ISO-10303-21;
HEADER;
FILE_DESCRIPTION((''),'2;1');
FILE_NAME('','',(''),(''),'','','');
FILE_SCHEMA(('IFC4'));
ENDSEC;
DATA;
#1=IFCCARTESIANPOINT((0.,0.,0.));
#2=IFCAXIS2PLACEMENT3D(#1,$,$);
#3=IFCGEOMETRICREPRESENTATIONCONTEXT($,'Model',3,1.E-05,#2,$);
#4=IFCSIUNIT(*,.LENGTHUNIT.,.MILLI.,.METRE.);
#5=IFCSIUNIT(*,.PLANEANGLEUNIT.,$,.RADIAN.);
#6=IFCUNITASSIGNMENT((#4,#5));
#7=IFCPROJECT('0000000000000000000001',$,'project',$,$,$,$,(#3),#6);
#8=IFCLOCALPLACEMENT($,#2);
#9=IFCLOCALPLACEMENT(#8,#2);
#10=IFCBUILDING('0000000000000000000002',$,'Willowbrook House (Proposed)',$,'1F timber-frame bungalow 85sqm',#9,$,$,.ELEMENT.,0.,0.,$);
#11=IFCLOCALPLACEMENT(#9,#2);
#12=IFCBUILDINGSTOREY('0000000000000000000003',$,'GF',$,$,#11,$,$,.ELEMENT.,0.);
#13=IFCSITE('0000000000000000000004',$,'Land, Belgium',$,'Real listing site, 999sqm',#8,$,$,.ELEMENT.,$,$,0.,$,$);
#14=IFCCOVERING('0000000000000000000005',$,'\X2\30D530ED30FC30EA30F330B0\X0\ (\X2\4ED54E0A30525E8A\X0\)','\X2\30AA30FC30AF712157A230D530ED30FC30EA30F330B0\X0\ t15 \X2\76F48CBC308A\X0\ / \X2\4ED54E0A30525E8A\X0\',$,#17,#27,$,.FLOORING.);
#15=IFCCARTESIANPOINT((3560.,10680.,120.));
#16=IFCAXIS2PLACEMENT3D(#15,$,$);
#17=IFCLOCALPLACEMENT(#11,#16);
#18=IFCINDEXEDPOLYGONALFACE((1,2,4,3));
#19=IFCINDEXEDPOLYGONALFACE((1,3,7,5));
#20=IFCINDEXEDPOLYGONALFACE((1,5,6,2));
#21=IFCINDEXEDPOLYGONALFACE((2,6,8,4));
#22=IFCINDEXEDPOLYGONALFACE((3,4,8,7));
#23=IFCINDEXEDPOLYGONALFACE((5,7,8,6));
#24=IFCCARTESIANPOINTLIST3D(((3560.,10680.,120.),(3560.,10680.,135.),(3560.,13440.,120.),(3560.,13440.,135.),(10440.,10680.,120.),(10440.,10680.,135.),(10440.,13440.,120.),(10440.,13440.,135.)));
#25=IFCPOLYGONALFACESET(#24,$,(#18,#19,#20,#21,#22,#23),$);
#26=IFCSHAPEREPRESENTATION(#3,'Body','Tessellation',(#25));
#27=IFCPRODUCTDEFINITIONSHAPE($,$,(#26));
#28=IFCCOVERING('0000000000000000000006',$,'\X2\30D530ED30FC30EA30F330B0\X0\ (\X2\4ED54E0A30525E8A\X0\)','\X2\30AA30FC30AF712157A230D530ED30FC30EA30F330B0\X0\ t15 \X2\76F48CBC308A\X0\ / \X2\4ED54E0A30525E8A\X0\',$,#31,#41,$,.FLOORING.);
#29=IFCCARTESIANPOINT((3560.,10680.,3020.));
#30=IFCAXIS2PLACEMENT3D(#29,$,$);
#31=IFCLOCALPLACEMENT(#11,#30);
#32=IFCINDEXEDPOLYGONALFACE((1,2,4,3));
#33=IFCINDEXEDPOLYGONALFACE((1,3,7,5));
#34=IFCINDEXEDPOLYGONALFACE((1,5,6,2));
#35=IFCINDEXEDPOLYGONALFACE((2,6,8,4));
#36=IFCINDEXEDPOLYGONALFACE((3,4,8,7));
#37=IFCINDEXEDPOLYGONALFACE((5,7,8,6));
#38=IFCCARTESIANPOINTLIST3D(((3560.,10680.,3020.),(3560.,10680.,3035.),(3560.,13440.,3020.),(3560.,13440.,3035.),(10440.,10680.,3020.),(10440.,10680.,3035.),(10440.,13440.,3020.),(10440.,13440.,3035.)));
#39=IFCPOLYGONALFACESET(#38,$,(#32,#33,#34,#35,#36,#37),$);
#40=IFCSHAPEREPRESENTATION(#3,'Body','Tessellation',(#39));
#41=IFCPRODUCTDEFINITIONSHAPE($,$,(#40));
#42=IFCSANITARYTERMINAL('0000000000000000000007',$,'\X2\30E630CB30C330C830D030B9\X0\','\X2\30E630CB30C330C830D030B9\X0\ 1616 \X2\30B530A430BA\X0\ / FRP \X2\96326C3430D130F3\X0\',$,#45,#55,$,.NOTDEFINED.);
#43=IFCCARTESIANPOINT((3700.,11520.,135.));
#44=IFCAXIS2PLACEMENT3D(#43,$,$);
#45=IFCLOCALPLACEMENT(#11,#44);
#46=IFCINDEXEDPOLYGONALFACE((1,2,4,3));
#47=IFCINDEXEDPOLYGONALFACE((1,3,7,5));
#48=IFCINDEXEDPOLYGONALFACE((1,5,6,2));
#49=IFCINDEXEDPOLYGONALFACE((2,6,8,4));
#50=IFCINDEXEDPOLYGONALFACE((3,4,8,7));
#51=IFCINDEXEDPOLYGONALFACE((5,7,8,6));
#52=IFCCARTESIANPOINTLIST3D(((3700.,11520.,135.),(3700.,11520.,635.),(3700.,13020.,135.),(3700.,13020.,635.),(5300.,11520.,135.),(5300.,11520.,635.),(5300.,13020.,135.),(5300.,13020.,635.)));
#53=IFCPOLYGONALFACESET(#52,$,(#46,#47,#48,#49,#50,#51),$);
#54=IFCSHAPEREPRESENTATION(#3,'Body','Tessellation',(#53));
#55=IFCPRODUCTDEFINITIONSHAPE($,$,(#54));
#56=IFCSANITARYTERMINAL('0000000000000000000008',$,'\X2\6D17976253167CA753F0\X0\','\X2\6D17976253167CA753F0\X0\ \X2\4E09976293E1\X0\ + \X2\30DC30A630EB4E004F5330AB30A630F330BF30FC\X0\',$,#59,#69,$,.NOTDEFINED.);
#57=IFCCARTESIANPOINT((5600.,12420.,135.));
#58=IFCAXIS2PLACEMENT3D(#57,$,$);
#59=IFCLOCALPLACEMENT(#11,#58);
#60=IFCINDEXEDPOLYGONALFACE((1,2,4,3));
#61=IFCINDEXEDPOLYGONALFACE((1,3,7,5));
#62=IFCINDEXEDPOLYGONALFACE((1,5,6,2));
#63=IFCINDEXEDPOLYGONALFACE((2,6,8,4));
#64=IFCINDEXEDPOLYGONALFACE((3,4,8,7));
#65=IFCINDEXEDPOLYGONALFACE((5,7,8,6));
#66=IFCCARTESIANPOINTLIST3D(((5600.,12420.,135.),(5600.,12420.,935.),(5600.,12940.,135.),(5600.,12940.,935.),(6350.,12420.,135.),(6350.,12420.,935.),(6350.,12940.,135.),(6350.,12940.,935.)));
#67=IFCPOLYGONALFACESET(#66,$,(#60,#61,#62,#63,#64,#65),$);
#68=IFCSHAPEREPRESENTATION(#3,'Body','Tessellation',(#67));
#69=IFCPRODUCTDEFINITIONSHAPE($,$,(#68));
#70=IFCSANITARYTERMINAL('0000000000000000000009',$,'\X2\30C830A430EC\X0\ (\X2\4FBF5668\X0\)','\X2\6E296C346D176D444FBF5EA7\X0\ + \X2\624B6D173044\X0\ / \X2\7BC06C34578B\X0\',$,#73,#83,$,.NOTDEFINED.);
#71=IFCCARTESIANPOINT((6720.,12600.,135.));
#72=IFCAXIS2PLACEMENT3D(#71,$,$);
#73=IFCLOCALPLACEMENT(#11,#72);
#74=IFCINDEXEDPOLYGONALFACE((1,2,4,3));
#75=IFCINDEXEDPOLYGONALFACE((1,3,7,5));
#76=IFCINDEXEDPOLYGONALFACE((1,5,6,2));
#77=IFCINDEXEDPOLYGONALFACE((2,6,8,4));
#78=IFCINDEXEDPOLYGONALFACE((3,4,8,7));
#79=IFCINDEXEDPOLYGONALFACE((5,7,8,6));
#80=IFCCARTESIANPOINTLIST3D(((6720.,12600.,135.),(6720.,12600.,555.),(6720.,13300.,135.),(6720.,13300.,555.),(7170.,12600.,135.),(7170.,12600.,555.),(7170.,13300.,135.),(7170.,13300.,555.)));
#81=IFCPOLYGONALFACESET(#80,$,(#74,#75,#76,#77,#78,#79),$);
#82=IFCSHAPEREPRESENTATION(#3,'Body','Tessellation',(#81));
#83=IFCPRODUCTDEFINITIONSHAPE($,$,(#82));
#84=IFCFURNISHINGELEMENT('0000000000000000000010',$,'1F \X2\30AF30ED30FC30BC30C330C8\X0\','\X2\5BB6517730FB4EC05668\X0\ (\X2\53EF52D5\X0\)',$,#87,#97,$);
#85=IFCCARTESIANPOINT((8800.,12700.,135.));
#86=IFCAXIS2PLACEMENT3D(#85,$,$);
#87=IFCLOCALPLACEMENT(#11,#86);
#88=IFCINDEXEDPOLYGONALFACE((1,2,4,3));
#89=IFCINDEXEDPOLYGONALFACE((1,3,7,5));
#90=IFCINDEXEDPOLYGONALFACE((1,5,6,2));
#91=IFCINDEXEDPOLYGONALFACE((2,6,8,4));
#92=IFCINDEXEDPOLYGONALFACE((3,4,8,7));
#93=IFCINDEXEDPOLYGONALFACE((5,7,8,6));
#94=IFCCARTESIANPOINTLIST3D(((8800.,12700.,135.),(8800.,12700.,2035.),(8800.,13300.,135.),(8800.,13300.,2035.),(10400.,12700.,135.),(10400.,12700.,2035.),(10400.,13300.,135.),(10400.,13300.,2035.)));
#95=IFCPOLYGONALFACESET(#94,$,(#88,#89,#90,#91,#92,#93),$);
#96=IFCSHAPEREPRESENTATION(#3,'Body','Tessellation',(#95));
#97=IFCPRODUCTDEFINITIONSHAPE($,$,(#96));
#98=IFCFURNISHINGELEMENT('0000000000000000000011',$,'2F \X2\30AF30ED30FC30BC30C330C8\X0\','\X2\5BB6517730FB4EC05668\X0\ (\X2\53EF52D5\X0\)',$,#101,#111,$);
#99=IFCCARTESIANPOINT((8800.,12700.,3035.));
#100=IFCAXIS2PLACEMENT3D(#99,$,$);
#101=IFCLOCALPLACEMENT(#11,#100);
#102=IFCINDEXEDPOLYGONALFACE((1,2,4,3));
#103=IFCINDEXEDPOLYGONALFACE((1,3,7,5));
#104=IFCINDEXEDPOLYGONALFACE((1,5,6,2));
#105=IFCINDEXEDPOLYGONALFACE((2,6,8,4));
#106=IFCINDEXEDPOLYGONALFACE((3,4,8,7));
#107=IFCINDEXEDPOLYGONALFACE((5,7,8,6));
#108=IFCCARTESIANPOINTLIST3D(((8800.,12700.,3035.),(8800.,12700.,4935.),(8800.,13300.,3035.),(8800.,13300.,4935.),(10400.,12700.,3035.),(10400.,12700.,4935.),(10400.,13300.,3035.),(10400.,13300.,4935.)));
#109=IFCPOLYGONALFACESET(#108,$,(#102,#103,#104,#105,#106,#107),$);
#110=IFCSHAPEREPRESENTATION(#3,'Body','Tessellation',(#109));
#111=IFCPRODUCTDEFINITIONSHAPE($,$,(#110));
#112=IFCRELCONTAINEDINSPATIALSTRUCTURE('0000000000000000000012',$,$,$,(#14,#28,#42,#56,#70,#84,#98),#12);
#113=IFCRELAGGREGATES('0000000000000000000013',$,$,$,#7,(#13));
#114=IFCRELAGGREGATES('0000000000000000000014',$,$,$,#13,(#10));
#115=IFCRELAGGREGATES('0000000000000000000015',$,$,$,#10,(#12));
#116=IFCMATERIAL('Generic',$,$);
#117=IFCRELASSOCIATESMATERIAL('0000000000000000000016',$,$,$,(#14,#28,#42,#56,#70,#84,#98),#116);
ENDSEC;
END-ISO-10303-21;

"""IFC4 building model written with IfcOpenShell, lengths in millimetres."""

from ifc_helpers import new_model, si_unit, frame, frame_2d, origin, place, context, project, spatial, rectangle, extrude, material, element, save


model = new_model("IFC4")

# Units and contexts
model_context = context("Model", 3, precision=1e-05, world=origin())
ifc_project = project(units=[si_unit("LENGTHUNIT", "METRE", prefix="MILLI"), si_unit("PLANEANGLEUNIT", "RADIAN")], contexts=[model_context])

# Site, building, storey
site_placement = place(None, origin())
site = spatial("IfcSite", under=ifc_project, at=site_placement, Name="Land, Belgium", ObjectType="Real listing site, 999sqm", CompositionType="ELEMENT", RefElevation=0.0)
building_placement = place(site_placement, origin())
building = spatial("IfcBuilding", under=site, at=building_placement, Name="Willowbrook House (Proposed)", ObjectType="1F timber-frame bungalow 85sqm", CompositionType="ELEMENT", ElevationOfRefHeight=0.0, ElevationOfTerrain=0.0)
storey_placement = place(building_placement, origin())
storey = spatial("IfcBuildingStorey", under=building, at=storey_placement, Name="GF", CompositionType="ELEMENT", Elevation=0.0)

# Coverings
ifc_material_1 = material(Name="Generic")
covering_1_placement = place(storey_placement, frame((3560.0, 10680.0, 120.0)))
element("IfcCovering", 1, at=covering_1_placement, inside=storey, material=ifc_material_1, Name="フローリング (仕上げ床)", Description="オーク無垢フローリング t15 直貼り / 仕上げ床", PredefinedType="FLOORING", context=model_context, shape_type="SweptSolid", body=[
    extrude(rectangle(XDim=6880.0, YDim=2760.0, at=frame_2d((3440.0, 1380.0))), frame((3560.0, 10680.0, 120.0)), (0.0, 0.0, 1.0), 15.0),
])
covering_2_placement = place(storey_placement, frame((3560.0, 10680.0, 3020.0)))
element("IfcCovering", 2, at=covering_2_placement, inside=storey, material=ifc_material_1, Name="フローリング (仕上げ床)", Description="オーク無垢フローリング t15 直貼り / 仕上げ床", PredefinedType="FLOORING", context=model_context, shape_type="SweptSolid", body=[
    extrude(rectangle(XDim=6880.0, YDim=2760.0, at=frame_2d((3440.0, 1380.0))), frame((3560.0, 10680.0, 3020.0)), (0.0, 0.0, 1.0), 15.0),
])

# Sanitary terminals
sanitary_terminal_1_placement = place(storey_placement, frame((3700.0, 11520.0, 135.0)))
element("IfcSanitaryTerminal", 3, at=sanitary_terminal_1_placement, inside=storey, material=ifc_material_1, Name="ユニットバス", Description="ユニットバス 1616 サイズ / FRP 防水パン", PredefinedType="NOTDEFINED", context=model_context, shape_type="SweptSolid", body=[
    extrude(rectangle(XDim=1600.0, YDim=1500.0, at=frame_2d((800.0, 750.0))), frame((3700.0, 11520.0, 135.0)), (0.0, 0.0, 1.0), 500.0),
])
sanitary_terminal_2_placement = place(storey_placement, frame((5600.0, 12420.0, 135.0)))
element("IfcSanitaryTerminal", 4, at=sanitary_terminal_2_placement, inside=storey, material=ifc_material_1, Name="洗面化粧台", Description="洗面化粧台 三面鏡 + ボウル一体カウンター", PredefinedType="NOTDEFINED", context=model_context, shape_type="SweptSolid", body=[
    extrude(rectangle(XDim=750.0, YDim=520.0, at=frame_2d((375.0, 260.0))), frame((5600.0, 12420.0, 135.0)), (0.0, 0.0, 1.0), 800.0),
])
sanitary_terminal_3_placement = place(storey_placement, frame((6720.0, 12600.0, 135.0)))
element("IfcSanitaryTerminal", 5, at=sanitary_terminal_3_placement, inside=storey, material=ifc_material_1, Name="トイレ (便器)", Description="温水洗浄便座 + 手洗い / 節水型", PredefinedType="NOTDEFINED", context=model_context, shape_type="SweptSolid", body=[
    extrude(rectangle(XDim=450.0, YDim=700.0, at=frame_2d((225.0, 350.0))), frame((6720.0, 12600.0, 135.0)), (0.0, 0.0, 1.0), 420.0),
])

# Furnishing elements
furnishing_1_placement = place(storey_placement, frame((8800.0, 12700.0, 135.0)))
element("IfcFurnishingElement", 6, at=furnishing_1_placement, inside=storey, material=ifc_material_1, Name="1F クローゼット", Description="家具・什器 (可動)", context=model_context, shape_type="SweptSolid", body=[
    extrude(rectangle(XDim=1600.0, YDim=600.0, at=frame_2d((800.0, 300.0))), frame((8800.0, 12700.0, 135.0)), (0.0, 0.0, 1.0), 1900.0),
])
furnishing_2_placement = place(storey_placement, frame((8800.0, 12700.0, 3035.0)))
element("IfcFurnishingElement", 7, at=furnishing_2_placement, inside=storey, material=ifc_material_1, Name="2F クローゼット", Description="家具・什器 (可動)", context=model_context, shape_type="SweptSolid", body=[
    extrude(rectangle(XDim=1600.0, YDim=600.0, at=frame_2d((800.0, 300.0))), frame((8800.0, 12700.0, 3035.0)), (0.0, 0.0, 1.0), 1900.0),
])

save(model, "model.ifc")
